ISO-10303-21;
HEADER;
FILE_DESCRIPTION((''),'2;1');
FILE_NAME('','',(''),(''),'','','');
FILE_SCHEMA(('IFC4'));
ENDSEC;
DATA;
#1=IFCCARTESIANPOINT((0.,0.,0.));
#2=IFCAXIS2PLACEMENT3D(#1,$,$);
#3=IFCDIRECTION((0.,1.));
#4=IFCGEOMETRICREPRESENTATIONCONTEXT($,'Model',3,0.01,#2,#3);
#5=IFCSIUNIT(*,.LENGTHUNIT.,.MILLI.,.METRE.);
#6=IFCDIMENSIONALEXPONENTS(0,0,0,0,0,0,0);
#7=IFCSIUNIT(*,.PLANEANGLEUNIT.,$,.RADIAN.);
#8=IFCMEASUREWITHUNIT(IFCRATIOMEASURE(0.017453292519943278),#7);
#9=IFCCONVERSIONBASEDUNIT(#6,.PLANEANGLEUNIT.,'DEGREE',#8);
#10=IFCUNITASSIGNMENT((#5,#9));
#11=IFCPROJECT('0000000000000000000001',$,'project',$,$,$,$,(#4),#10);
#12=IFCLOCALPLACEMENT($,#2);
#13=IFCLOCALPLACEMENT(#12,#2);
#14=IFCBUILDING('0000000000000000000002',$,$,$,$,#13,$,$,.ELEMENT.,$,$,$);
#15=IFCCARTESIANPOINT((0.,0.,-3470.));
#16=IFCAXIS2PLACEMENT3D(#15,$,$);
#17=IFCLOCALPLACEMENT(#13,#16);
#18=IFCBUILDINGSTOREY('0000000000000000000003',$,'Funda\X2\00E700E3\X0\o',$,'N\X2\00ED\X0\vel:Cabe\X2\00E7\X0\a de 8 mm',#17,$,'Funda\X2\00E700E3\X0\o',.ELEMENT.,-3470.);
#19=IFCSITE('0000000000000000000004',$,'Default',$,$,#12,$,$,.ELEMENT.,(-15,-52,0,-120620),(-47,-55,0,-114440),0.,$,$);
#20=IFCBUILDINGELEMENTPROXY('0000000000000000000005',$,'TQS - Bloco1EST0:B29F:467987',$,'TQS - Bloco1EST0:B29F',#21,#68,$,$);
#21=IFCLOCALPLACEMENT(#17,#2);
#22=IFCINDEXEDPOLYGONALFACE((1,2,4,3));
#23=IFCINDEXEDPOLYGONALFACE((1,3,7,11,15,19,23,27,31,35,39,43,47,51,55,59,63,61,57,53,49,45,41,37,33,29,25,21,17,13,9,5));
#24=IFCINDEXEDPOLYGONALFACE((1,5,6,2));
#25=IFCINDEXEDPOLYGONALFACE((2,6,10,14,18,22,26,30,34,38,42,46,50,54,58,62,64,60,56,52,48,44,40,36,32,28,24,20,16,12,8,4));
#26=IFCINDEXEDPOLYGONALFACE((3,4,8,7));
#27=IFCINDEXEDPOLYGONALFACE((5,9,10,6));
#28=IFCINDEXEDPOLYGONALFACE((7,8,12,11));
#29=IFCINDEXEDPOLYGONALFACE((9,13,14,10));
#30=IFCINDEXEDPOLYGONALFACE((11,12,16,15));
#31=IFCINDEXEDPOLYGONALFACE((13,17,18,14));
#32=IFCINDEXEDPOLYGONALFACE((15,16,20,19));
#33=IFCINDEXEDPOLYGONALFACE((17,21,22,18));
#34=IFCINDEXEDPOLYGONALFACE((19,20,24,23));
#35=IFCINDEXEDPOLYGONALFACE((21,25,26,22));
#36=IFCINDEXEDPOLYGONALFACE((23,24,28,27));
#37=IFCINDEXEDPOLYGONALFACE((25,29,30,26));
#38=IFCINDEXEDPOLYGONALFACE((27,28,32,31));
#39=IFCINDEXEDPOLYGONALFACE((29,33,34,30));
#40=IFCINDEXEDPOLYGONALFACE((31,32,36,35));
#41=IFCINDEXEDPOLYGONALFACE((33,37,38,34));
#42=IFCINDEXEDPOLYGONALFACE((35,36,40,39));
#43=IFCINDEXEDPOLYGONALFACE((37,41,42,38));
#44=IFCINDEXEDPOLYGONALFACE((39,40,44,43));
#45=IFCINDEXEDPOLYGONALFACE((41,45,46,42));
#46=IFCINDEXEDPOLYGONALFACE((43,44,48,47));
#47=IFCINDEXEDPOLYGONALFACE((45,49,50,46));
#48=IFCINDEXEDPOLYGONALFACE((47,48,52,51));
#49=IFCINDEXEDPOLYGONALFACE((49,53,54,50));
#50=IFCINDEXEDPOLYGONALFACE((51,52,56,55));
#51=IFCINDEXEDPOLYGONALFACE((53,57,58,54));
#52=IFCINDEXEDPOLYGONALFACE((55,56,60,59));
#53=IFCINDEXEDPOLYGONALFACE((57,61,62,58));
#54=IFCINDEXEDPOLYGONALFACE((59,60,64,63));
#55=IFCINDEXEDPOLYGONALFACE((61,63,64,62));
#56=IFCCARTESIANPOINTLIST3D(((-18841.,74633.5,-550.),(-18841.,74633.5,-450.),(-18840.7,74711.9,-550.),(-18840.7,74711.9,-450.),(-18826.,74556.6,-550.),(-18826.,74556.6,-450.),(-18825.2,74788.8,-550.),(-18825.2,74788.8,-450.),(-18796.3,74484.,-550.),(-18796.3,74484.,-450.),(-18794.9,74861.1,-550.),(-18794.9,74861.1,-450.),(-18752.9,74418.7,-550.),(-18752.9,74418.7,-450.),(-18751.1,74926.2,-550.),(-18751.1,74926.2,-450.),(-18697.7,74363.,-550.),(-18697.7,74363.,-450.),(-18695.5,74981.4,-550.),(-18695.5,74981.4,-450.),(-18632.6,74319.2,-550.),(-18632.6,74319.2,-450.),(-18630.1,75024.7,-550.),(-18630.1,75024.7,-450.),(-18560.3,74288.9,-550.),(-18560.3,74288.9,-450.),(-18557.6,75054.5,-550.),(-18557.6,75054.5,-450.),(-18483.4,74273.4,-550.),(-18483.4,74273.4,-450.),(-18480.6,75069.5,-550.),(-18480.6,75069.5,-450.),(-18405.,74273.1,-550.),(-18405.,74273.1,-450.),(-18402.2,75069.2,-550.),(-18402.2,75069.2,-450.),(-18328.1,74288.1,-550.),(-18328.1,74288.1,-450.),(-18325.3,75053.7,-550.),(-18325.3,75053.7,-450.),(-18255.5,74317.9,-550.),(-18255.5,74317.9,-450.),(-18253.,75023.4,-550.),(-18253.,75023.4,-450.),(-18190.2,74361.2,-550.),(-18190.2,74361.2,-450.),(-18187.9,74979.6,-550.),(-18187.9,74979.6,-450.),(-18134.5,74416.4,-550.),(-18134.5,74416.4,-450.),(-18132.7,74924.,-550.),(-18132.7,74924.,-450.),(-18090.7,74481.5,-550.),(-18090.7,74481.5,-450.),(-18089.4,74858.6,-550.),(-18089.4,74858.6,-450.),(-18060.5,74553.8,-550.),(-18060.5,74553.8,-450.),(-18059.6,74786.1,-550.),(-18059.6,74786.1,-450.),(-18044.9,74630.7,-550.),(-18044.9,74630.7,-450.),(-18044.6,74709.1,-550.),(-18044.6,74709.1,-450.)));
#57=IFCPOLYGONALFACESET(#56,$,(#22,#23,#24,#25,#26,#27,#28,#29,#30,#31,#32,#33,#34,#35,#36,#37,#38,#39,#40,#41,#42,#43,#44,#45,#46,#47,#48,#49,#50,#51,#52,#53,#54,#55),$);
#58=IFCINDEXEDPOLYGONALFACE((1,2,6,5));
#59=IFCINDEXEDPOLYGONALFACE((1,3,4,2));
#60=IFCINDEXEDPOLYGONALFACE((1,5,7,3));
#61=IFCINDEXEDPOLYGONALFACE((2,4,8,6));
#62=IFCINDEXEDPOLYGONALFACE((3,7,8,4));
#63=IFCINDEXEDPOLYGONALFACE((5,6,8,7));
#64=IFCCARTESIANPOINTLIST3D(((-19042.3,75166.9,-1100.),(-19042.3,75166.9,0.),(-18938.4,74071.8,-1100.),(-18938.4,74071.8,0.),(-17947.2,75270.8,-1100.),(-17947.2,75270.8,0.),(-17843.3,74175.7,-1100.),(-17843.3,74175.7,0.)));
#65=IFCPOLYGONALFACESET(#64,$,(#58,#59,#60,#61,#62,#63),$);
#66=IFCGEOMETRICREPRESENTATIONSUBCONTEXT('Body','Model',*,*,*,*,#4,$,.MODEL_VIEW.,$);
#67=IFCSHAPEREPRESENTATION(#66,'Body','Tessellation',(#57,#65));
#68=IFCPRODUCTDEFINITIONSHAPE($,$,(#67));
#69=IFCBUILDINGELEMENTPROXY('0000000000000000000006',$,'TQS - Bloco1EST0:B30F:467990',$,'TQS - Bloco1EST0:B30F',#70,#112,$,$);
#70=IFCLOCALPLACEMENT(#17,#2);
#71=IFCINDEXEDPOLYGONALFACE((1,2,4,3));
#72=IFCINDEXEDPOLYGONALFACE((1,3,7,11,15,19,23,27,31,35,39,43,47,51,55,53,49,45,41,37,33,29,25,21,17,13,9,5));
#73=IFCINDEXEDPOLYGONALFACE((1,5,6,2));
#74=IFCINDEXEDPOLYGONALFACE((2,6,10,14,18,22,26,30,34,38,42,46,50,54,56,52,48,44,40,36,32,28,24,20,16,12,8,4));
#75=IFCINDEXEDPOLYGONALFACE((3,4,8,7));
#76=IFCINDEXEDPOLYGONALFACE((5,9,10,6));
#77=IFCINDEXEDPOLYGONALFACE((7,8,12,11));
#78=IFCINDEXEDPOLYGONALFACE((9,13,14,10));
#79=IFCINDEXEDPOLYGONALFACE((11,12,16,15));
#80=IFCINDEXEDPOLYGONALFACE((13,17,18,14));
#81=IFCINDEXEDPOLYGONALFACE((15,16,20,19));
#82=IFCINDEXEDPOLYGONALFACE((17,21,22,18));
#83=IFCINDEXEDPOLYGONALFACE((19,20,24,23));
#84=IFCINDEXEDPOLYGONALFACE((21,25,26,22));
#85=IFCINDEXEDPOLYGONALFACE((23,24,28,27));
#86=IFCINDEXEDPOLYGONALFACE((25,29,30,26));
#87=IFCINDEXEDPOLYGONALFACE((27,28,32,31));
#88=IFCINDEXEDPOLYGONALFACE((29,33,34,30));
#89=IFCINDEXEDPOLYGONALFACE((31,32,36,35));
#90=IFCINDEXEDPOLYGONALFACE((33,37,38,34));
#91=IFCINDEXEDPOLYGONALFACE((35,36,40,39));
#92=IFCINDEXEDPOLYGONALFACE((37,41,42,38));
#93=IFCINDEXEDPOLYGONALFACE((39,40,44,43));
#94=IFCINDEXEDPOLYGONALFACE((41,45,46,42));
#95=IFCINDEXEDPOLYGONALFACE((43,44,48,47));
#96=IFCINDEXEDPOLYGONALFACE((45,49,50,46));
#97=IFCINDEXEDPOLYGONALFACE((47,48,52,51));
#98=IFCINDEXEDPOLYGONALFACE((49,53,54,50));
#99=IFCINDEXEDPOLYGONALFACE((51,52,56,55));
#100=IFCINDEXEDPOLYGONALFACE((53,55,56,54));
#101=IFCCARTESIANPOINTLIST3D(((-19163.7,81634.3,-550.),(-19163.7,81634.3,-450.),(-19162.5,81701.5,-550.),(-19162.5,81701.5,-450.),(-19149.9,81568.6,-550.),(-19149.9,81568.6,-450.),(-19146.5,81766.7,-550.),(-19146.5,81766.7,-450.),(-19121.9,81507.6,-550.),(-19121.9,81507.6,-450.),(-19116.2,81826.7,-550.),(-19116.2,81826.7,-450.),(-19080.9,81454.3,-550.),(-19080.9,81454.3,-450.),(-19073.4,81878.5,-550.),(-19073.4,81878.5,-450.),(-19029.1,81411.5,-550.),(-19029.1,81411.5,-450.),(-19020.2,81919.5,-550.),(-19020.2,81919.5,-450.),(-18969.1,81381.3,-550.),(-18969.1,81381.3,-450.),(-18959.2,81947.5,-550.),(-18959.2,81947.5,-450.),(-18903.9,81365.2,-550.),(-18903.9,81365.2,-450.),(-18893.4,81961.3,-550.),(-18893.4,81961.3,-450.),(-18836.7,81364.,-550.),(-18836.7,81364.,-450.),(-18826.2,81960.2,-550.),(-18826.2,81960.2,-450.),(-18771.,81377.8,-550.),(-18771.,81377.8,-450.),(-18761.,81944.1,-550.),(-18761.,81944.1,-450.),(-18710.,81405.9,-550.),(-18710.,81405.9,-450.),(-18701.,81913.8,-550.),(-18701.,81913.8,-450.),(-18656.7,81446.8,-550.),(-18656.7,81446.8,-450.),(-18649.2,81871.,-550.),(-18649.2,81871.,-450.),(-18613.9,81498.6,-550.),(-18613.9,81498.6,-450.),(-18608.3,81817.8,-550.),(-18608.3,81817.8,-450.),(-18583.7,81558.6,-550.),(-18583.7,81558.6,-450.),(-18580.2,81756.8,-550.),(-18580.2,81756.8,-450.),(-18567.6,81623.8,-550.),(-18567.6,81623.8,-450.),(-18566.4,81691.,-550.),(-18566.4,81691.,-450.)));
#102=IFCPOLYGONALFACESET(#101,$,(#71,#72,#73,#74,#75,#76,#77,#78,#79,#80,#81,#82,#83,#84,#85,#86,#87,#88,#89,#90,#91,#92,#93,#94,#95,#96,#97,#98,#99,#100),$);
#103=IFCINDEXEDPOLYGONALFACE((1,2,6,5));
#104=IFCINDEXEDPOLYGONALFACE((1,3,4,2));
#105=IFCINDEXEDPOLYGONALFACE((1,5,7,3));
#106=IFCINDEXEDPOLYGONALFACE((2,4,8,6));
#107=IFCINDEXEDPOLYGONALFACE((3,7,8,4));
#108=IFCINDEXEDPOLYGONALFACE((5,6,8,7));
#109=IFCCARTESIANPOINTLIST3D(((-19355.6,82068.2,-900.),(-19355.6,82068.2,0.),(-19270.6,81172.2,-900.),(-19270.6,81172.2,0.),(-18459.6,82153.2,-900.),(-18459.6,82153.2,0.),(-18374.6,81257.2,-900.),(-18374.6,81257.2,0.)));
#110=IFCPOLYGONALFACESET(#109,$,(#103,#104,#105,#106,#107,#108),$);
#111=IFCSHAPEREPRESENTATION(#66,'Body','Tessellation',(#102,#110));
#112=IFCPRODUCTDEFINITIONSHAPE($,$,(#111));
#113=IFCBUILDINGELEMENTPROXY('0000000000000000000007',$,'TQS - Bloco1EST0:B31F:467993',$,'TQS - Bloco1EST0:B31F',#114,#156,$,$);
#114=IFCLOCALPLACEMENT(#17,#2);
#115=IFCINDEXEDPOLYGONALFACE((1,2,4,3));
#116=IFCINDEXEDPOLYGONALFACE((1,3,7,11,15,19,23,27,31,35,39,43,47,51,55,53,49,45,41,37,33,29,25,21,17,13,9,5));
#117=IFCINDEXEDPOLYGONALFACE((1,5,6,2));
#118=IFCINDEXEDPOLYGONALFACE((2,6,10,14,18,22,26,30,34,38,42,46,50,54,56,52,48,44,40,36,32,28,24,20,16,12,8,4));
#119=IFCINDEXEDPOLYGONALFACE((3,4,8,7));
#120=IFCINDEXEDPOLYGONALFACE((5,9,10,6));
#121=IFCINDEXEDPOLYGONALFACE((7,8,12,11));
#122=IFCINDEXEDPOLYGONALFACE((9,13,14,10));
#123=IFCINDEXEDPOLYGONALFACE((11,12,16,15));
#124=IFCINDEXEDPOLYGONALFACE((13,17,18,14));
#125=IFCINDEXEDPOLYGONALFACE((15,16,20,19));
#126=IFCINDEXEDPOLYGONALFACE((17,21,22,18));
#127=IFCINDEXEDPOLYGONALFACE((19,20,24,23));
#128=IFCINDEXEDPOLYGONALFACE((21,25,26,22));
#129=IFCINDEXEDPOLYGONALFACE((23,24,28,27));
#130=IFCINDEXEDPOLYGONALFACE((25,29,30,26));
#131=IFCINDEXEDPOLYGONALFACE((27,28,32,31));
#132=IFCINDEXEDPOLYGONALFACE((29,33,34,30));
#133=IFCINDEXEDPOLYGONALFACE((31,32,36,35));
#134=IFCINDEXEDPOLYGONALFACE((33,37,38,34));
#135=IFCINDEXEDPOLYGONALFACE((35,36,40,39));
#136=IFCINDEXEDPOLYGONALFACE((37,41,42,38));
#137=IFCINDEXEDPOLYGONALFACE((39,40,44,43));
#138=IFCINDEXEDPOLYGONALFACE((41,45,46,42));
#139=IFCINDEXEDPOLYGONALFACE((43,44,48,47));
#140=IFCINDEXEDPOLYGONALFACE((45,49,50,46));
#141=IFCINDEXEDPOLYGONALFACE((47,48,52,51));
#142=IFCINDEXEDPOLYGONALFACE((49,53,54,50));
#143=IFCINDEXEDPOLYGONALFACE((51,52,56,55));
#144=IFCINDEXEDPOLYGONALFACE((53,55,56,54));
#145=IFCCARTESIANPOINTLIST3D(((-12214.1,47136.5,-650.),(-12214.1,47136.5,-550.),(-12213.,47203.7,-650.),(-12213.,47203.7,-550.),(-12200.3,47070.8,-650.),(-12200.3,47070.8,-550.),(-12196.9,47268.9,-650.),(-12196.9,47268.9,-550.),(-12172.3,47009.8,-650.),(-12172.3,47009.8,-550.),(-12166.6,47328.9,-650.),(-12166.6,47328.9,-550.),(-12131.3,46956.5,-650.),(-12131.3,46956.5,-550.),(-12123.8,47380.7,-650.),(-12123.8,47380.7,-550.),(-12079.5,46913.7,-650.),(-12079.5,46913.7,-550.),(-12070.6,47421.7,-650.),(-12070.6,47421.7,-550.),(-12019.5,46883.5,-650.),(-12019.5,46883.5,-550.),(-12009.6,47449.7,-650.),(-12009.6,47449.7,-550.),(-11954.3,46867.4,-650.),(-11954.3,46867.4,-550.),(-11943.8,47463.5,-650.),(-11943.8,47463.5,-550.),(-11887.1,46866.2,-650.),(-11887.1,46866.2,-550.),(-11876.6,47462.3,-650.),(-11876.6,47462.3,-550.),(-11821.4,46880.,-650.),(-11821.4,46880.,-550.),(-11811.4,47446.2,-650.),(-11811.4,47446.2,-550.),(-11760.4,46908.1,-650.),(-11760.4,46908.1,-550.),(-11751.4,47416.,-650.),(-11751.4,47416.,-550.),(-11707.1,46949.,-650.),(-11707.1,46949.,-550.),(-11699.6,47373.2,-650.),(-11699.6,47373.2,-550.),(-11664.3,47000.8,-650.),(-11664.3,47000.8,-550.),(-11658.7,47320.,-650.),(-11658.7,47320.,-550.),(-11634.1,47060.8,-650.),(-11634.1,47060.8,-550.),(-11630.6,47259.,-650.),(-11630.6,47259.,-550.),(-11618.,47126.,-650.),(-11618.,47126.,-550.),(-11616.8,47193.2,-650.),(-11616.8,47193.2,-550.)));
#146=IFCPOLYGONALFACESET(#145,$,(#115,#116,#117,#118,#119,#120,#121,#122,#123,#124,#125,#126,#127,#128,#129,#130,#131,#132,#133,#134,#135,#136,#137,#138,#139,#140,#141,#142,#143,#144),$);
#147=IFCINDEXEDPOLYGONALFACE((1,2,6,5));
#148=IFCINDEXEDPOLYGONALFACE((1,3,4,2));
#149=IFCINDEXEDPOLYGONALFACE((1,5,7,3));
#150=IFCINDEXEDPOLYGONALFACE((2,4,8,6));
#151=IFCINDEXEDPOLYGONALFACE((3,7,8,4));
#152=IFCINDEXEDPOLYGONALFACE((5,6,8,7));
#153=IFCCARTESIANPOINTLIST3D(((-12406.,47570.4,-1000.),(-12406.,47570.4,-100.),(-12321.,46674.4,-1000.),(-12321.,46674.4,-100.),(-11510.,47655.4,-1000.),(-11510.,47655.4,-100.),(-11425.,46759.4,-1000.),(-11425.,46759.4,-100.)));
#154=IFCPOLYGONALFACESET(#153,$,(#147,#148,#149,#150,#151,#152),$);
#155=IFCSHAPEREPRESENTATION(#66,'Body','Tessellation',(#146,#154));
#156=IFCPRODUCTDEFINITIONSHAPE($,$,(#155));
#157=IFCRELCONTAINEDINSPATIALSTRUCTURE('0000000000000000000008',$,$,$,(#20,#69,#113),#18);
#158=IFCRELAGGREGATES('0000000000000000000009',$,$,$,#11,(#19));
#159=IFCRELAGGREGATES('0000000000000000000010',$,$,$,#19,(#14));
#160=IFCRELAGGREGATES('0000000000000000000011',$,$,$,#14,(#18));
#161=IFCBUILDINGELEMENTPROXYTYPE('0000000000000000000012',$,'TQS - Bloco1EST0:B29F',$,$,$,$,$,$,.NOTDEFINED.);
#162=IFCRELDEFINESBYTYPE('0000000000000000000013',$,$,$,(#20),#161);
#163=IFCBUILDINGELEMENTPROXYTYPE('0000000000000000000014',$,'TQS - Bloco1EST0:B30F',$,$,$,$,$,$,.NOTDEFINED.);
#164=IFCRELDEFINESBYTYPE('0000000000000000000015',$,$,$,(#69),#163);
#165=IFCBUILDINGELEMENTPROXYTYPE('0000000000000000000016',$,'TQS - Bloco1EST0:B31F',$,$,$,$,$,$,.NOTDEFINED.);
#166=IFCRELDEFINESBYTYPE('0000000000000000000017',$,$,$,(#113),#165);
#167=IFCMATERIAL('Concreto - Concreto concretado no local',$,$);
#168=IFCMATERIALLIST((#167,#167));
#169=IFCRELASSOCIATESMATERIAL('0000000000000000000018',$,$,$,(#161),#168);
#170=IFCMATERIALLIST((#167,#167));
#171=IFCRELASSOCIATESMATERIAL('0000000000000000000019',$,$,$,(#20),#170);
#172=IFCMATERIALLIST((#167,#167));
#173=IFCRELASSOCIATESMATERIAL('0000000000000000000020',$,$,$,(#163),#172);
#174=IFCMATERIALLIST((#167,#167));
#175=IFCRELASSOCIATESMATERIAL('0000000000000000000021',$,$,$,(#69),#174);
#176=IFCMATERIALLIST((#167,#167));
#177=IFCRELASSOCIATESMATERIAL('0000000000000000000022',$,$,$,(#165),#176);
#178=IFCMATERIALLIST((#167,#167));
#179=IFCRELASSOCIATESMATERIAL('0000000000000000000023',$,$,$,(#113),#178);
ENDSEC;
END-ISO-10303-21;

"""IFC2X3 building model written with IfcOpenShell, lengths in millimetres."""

from ifc_helpers import new_model, entity, si_unit, converted_unit, direction, frame, frame_2d, origin, origin_2d_with_axis, place, context, subcontext, project, spatial, rectangle, circle, extrude, source, transform, mapped, material, material_list, type_object, type_shapes, element, save


model = new_model("IFC2X3")

# Units and contexts
model_context = context("Model", 3, precision=0.01, world=origin(), true_north=direction((0.0, 1.0)))
body_context = subcontext(model_context, "Body", "Model", "MODEL_VIEW")
ifc_project = project(units=[si_unit("LENGTHUNIT", "METRE", prefix="MILLI"), converted_unit("PLANEANGLEUNIT", "DEGREE", entity("IfcRatioMeasure", 0.017453292519943278), si_unit("PLANEANGLEUNIT", "RADIAN"), dimensions=[0, 0, 0, 0, 0, 0, 0])], contexts=[model_context])

# Site, building, storey
site_placement = place(None, origin())
site = spatial("IfcSite", under=ifc_project, at=site_placement, Name="Default", CompositionType="ELEMENT", RefLatitude=(-15, -52, 0, -120620), RefLongitude=(-47, -55, 0, -114440), RefElevation=0.0)
building_placement = place(site_placement, origin())
building = spatial("IfcBuilding", under=site, at=building_placement, CompositionType="ELEMENT")
storey_placement = place(building_placement, frame((0.0, 0.0, -3470.0)))
storey = spatial("IfcBuildingStorey", under=building, at=storey_placement, Name="Fundação", ObjectType="Nível:Cabeça de 8 mm", LongName="Fundação", CompositionType="ELEMENT", Elevation=-3470.0)

# Building element proxies
ifc_material_1 = material(Name="Concreto - Concreto concretado no local")
ifc_material_list_1 = material_list([ifc_material_1, ifc_material_1])
ifc_material_list_2 = material_list([ifc_material_1, ifc_material_1])
building_element_proxy_type_1 = type_object("IfcBuildingElementProxyType", Name="TQS - Bloco1EST0:B29F", PredefinedType="NOTDEFINED", material=ifc_material_list_2)
shared_shape_1 = source(origin(), body_context, "Body", "SweptSolid", [
    extrude(circle(Radius=400.0, at=frame_2d((0.0, 0.0), x_axis=(1.0, 0.0))), frame((0.0, 0.0, -550.0)), (0.0, 0.0, 1.0), 100.0),
    extrude(rectangle(XDim=1100.0, YDim=1100.0, at=origin_2d_with_axis()), frame((0.0, 0.0, -1100.0), z_axis=(0.0, 0.0, 1.0), x_axis=(-1.0, 0.0, 0.0)), (0.0, 0.0, 1.0), 1100.0),
])
type_shapes(building_element_proxy_type_1, [shared_shape_1])
proxy_1_placement = place(storey_placement, frame((-18442.8, 74671.3, 0.0), z_axis=(0.0, 0.0, 1.0), x_axis=(-0.094456, 0.995529, 0.0)))
element("IfcBuildingElementProxy", 1, at=proxy_1_placement, inside=storey, type_object=building_element_proxy_type_1, material=ifc_material_list_1, Name="TQS - Bloco1EST0:B29F:467987", ObjectType="TQS - Bloco1EST0:B29F", context=body_context, shape_type="MappedRepresentation", body=[
    mapped(shared_shape_1, transform((0.0, 0.0, 0.0), scale=1.0)),
])
ifc_material_list_3 = material_list([ifc_material_1, ifc_material_1])
ifc_material_list_4 = material_list([ifc_material_1, ifc_material_1])
building_element_proxy_type_2 = type_object("IfcBuildingElementProxyType", Name="TQS - Bloco1EST0:B30F", PredefinedType="NOTDEFINED", material=ifc_material_list_4)
shared_shape_2 = source(origin(), body_context, "Body", "SweptSolid", [
    extrude(circle(Radius=300.0, at=frame_2d((0.0, 0.0), x_axis=(1.0, 0.0))), frame((0.0, 0.0, -550.0)), (0.0, 0.0, 1.0), 100.0),
    extrude(rectangle(XDim=900.0, YDim=900.0, at=origin_2d_with_axis()), frame((0.0, 0.0, -900.0), z_axis=(0.0, 0.0, 1.0), x_axis=(-1.0, 0.0, 0.0)), (0.0, 0.0, 1.0), 900.0),
])
type_shapes(building_element_proxy_type_2, [shared_shape_2])
proxy_2_placement = place(storey_placement, frame((-18865.1, 81662.7, 0.0), z_axis=(0.0, 0.0, 1.0), x_axis=(-0.094456, 0.995529, 0.0)))
element("IfcBuildingElementProxy", 2, at=proxy_2_placement, inside=storey, type_object=building_element_proxy_type_2, material=ifc_material_list_3, Name="TQS - Bloco1EST0:B30F:467990", ObjectType="TQS - Bloco1EST0:B30F", context=body_context, shape_type="MappedRepresentation", body=[
    mapped(shared_shape_2, transform((0.0, 0.0, 0.0), scale=1.0)),
])
ifc_material_list_5 = material_list([ifc_material_1, ifc_material_1])
ifc_material_list_6 = material_list([ifc_material_1, ifc_material_1])
building_element_proxy_type_3 = type_object("IfcBuildingElementProxyType", Name="TQS - Bloco1EST0:B31F", PredefinedType="NOTDEFINED", material=ifc_material_list_6)
shared_shape_3 = source(origin(), body_context, "Body", "SweptSolid", [
    extrude(circle(Radius=300.0, at=frame_2d((0.0, 0.0), x_axis=(1.0, 0.0))), frame((0.0, 0.0, -550.0)), (0.0, 0.0, 1.0), 100.0),
    extrude(rectangle(XDim=900.0, YDim=900.0, at=origin_2d_with_axis()), frame((0.0, 0.0, -900.0), z_axis=(0.0, 0.0, 1.0), x_axis=(-1.0, 0.0, 0.0)), (0.0, 0.0, 1.0), 900.0),
])
type_shapes(building_element_proxy_type_3, [shared_shape_3])
proxy_3_placement = place(storey_placement, frame((-11915.5, 47164.9, -100.0), z_axis=(0.0, 0.0, 1.0), x_axis=(-0.094456, 0.995529, 0.0)))
element("IfcBuildingElementProxy", 3, at=proxy_3_placement, inside=storey, type_object=building_element_proxy_type_3, material=ifc_material_list_5, Name="TQS - Bloco1EST0:B31F:467993", ObjectType="TQS - Bloco1EST0:B31F", context=body_context, shape_type="MappedRepresentation", body=[
    mapped(shared_shape_3, transform((0.0, 0.0, 0.0), scale=1.0)),
])

save(model, "model.ifc")
